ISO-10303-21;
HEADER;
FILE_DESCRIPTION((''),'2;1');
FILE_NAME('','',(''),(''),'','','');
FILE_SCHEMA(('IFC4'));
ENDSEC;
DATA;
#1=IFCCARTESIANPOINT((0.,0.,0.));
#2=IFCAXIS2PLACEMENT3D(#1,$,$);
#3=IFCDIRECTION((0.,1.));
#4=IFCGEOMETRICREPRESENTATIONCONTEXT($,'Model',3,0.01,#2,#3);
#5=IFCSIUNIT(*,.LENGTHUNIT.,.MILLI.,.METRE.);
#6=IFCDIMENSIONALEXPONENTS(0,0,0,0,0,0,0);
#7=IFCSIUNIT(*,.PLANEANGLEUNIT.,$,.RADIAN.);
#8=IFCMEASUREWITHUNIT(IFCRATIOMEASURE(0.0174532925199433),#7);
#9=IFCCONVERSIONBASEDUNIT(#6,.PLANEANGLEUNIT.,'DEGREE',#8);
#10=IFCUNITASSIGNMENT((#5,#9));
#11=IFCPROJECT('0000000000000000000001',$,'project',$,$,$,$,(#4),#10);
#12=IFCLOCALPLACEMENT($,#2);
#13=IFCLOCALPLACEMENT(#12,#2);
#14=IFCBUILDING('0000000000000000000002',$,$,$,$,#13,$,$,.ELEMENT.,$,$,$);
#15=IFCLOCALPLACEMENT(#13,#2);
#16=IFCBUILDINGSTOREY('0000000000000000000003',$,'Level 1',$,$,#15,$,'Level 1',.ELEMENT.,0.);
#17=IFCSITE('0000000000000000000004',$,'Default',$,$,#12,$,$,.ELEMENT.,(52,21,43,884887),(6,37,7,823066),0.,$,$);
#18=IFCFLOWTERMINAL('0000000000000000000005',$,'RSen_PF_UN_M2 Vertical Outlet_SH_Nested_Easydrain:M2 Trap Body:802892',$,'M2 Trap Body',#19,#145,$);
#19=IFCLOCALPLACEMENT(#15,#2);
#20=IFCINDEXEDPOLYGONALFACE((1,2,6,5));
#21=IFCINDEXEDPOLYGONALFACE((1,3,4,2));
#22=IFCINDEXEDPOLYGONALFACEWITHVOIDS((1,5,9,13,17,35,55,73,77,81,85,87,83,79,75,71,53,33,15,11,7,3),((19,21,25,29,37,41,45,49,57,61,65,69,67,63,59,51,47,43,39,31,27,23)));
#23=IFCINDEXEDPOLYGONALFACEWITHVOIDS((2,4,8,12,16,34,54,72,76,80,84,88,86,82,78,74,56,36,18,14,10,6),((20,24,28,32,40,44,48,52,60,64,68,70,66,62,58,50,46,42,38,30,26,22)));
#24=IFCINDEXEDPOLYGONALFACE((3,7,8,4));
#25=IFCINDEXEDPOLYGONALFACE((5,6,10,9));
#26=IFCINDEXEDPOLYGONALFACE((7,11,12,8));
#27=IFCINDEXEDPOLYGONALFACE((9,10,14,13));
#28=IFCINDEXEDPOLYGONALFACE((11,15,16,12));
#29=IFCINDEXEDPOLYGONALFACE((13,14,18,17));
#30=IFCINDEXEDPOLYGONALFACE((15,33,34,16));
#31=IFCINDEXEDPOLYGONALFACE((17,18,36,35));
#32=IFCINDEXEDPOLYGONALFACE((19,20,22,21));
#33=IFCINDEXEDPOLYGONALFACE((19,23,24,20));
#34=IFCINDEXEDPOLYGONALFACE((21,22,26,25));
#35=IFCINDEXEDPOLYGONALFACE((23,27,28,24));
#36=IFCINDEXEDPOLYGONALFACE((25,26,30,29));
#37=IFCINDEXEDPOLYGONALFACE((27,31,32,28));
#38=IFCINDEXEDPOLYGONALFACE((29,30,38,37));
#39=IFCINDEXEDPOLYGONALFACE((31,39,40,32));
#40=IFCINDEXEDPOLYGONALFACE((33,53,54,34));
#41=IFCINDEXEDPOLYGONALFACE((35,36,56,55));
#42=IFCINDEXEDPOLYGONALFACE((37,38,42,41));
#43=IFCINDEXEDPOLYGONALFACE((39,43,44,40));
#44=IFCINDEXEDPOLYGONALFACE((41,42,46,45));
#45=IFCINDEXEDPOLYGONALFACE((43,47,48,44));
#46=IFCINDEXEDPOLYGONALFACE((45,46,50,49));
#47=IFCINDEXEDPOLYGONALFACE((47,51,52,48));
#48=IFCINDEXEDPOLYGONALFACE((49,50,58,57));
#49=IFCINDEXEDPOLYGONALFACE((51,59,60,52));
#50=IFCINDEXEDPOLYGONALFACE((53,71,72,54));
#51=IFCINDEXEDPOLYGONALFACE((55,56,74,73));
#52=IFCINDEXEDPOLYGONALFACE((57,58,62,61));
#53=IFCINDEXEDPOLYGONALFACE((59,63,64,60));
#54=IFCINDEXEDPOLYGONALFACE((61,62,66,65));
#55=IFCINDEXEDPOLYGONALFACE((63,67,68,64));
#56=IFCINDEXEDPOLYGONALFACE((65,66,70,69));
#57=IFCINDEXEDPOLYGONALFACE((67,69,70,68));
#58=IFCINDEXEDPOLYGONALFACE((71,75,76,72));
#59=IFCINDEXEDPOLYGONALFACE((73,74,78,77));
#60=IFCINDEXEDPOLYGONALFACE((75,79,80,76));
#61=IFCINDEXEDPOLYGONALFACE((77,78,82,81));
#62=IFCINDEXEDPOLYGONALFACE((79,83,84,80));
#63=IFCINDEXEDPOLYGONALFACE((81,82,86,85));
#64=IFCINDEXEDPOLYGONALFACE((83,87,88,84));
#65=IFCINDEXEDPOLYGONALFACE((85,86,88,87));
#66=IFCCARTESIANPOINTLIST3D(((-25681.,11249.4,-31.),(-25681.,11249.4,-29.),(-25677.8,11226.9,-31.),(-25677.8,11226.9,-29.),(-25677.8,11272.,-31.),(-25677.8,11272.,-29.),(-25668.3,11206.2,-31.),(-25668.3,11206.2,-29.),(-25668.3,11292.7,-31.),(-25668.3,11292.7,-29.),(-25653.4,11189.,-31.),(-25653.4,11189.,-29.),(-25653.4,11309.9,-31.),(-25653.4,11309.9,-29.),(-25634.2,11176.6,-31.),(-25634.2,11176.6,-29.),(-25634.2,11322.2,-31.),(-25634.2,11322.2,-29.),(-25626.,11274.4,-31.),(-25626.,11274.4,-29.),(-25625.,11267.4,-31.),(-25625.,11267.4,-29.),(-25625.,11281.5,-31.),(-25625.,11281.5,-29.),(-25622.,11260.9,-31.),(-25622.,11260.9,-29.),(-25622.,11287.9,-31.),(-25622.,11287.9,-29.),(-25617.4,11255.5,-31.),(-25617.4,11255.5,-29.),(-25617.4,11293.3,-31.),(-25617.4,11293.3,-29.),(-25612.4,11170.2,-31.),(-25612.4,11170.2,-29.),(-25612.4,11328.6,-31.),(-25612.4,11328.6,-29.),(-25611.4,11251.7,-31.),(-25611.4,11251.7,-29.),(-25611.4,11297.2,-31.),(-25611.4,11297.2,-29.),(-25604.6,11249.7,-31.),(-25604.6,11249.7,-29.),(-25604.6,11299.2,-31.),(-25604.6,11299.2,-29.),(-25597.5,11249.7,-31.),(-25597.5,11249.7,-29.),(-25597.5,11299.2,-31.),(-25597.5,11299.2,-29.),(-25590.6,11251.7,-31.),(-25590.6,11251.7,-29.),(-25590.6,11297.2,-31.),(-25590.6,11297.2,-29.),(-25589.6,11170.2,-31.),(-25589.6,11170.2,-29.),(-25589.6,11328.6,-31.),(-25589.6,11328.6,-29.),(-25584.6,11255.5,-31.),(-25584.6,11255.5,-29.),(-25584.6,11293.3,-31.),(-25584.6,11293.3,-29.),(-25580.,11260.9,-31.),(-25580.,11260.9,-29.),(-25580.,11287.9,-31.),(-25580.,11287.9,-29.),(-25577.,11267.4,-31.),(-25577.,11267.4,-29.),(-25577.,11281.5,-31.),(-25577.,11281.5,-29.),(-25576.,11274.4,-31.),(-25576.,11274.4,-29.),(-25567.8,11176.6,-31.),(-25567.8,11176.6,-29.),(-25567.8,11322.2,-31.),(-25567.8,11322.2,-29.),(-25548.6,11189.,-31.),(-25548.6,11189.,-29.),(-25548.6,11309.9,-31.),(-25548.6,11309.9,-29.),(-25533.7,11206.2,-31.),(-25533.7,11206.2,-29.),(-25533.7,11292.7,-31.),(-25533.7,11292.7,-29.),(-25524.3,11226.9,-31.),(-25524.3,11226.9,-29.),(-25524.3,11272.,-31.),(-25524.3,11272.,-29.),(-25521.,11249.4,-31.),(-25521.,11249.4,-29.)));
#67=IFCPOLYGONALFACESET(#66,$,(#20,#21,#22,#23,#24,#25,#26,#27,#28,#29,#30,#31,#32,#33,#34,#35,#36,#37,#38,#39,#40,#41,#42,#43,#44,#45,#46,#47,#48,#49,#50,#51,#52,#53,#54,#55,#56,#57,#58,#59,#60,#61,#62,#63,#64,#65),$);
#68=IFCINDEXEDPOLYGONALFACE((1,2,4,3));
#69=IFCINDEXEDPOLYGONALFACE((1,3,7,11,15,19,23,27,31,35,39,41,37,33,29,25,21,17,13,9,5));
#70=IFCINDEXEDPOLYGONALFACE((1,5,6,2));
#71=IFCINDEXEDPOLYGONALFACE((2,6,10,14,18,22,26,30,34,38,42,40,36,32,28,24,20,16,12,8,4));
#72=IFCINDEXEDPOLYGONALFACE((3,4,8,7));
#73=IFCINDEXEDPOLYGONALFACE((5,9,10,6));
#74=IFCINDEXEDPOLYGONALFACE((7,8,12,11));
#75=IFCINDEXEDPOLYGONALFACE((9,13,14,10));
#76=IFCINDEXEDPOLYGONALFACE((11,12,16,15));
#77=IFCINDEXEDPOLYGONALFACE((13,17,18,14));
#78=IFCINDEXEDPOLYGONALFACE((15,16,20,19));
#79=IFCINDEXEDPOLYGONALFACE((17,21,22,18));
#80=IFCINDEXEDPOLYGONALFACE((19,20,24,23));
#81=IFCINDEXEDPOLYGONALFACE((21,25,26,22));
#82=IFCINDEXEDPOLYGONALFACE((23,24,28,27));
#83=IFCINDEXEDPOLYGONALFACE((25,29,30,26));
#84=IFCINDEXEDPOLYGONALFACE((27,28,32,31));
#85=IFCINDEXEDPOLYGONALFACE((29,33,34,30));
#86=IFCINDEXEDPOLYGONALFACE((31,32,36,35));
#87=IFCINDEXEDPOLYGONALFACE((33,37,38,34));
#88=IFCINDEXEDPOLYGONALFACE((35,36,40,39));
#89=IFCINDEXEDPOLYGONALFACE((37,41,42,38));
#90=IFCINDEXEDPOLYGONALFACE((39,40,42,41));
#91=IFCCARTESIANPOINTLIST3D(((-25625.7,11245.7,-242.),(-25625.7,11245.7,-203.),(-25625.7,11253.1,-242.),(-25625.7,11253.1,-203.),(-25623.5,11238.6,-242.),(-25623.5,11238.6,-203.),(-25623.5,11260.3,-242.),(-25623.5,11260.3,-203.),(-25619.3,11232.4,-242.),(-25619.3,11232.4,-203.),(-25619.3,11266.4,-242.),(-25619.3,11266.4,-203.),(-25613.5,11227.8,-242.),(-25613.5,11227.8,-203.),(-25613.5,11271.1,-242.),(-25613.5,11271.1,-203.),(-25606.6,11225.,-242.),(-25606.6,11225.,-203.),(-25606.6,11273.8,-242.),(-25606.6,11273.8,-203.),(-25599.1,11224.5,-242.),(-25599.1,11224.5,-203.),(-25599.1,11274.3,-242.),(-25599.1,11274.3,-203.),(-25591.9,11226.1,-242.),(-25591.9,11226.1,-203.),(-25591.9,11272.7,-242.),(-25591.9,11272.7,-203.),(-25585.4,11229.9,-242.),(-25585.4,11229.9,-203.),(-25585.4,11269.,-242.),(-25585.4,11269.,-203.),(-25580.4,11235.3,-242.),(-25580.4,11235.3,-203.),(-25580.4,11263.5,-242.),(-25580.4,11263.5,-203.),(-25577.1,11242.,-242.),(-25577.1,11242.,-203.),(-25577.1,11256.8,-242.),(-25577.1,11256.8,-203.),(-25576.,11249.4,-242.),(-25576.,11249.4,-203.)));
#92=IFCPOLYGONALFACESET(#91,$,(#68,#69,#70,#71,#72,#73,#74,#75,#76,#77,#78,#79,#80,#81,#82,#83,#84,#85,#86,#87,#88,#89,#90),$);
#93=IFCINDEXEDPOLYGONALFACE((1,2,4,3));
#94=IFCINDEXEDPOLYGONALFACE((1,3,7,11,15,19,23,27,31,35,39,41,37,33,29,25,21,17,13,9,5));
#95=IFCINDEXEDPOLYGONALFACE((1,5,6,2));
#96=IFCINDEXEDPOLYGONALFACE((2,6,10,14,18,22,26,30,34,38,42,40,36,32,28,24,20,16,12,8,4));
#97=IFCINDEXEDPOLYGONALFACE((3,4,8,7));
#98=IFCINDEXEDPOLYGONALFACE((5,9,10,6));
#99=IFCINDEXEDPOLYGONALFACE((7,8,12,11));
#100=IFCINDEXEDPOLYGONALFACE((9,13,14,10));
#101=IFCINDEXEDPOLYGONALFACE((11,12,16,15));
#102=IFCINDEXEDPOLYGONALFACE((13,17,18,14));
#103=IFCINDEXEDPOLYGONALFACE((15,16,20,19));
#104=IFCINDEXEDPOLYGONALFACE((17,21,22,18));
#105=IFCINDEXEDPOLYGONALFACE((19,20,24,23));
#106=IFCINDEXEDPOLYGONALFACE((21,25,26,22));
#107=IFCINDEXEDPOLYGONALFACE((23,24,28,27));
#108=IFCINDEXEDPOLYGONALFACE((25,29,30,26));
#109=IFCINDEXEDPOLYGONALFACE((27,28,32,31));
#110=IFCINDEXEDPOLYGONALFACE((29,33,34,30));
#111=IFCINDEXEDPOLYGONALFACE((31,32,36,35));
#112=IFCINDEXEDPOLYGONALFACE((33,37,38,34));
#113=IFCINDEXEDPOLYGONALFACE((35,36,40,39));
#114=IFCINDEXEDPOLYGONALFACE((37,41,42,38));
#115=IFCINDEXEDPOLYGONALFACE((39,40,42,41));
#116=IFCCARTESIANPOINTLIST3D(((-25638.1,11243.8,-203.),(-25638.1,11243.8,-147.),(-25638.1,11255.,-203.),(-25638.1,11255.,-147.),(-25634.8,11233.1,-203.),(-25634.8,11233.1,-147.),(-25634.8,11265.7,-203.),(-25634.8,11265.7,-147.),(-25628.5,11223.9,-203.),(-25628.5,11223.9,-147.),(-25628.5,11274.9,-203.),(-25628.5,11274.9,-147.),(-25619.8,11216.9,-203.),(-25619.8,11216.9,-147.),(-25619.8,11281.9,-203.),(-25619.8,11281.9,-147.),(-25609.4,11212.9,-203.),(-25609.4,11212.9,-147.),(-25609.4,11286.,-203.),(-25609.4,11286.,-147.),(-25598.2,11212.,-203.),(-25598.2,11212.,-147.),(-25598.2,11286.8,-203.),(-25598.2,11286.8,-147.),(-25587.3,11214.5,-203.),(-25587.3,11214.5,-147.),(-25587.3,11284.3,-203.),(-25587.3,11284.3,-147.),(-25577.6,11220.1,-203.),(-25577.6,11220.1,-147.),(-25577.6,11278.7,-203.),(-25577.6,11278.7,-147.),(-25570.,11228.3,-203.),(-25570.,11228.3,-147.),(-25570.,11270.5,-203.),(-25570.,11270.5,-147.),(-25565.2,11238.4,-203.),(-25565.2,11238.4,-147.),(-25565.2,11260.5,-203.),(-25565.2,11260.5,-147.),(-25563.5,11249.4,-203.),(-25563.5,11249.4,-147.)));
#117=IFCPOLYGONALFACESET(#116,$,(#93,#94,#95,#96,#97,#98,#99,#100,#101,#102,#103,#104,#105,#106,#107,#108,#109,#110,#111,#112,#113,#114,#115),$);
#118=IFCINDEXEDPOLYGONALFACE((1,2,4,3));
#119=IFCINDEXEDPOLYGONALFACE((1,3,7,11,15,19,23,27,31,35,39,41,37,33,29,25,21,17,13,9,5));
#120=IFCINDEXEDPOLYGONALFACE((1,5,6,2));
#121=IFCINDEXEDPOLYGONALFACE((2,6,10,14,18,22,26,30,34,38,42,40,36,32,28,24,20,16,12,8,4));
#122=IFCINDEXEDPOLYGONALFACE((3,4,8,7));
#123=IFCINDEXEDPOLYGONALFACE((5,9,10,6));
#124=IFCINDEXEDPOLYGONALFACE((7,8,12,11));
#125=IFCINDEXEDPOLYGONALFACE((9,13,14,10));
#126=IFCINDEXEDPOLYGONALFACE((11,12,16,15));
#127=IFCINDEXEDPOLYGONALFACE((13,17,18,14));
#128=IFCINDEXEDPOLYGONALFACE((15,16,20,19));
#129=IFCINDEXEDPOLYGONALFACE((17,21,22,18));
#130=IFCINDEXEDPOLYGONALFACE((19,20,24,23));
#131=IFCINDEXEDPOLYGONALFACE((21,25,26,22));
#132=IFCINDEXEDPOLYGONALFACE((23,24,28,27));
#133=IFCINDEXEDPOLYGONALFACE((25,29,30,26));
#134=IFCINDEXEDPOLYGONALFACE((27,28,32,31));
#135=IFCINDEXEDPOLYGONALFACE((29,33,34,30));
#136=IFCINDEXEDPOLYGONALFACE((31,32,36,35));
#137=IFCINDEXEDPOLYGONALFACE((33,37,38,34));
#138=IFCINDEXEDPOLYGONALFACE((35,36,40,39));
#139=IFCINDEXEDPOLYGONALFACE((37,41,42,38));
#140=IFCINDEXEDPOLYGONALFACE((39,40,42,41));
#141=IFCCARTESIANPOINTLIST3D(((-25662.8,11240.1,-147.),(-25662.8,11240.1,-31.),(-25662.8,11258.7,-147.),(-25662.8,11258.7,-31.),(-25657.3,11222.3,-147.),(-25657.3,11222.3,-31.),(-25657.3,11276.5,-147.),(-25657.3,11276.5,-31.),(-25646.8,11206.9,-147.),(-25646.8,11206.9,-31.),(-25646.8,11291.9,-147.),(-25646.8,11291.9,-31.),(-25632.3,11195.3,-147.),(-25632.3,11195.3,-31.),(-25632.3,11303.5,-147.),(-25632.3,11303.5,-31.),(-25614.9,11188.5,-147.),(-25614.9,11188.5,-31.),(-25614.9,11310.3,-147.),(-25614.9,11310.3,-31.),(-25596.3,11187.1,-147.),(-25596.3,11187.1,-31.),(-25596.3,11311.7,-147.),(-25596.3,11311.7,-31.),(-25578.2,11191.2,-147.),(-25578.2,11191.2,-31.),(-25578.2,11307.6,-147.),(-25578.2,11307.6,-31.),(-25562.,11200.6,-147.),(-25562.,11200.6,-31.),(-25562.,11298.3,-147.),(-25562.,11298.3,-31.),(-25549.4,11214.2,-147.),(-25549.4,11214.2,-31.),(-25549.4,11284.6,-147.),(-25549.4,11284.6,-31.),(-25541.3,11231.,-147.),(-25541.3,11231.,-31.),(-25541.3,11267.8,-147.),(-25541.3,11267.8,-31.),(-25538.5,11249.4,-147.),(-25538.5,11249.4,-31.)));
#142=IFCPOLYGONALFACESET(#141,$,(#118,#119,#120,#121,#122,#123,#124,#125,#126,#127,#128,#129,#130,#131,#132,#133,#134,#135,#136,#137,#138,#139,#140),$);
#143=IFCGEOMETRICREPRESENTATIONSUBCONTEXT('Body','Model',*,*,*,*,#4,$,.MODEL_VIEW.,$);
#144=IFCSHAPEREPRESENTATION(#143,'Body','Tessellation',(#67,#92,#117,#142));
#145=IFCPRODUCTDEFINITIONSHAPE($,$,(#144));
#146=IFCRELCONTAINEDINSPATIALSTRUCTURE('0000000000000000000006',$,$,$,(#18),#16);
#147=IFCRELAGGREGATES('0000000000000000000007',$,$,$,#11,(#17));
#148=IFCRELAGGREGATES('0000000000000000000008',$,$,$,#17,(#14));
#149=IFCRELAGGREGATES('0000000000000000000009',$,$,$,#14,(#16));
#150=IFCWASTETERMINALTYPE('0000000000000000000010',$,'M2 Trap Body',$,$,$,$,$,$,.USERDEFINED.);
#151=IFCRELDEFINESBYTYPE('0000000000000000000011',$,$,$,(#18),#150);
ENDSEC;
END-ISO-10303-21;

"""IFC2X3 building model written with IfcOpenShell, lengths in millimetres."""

from ifc_helpers import new_model, entity, si_unit, converted_unit, direction, frame, frame_2d, origin, origin_2d_with_axis, place, context, subcontext, project, spatial, circle_curve, parameter, trimmed, segment, composite_curve, circle, outline, extrude, source, transform, mapped, type_object, type_shapes, element, save


model = new_model("IFC2X3")

# Units and contexts
model_context = context("Model", 3, precision=0.01, world=origin(), true_north=direction((0.0, 1.0)))
body_context = subcontext(model_context, "Body", "Model", "MODEL_VIEW")
ifc_project = project(units=[si_unit("LENGTHUNIT", "METRE", prefix="MILLI"), converted_unit("PLANEANGLEUNIT", "DEGREE", entity("IfcRatioMeasure", 0.0174532925199433), si_unit("PLANEANGLEUNIT", "RADIAN"), dimensions=[0, 0, 0, 0, 0, 0, 0])], contexts=[model_context])

# Site, building, storey
site_placement = place(None, origin())
site = spatial("IfcSite", under=ifc_project, at=site_placement, Name="Default", CompositionType="ELEMENT", RefLatitude=(52, 21, 43, 884887), RefLongitude=(6, 37, 7, 823066), RefElevation=0.0)
building_placement = place(site_placement, origin())
building = spatial("IfcBuilding", under=site, at=building_placement, CompositionType="ELEMENT")
storey_placement = place(building_placement, origin())
storey = spatial("IfcBuildingStorey", under=building, at=storey_placement, Name="Level 1", LongName="Level 1", CompositionType="ELEMENT", Elevation=0.0)

# Flow terminal
waste_terminal_type_1 = type_object("IfcWasteTerminalType", Name="M2 Trap Body", PredefinedType="USERDEFINED")
shared_shape_1 = source(origin(), body_context, "Body", "SweptSolid", [
    extrude(outline(composite_curve([segment(trimmed(circle_curve(origin_2d_with_axis(), 80.0), [parameter(0.0)], [parameter(180.0)], True, "PARAMETER"), True, "CONTINUOUS"), segment(trimmed(circle_curve(origin_2d_with_axis(), 80.0), [parameter(180.0)], [parameter(360.0)], True, "PARAMETER"), True, "CONTINUOUS")], self_intersect=False), holes=[composite_curve([segment(trimmed(circle_curve(frame_2d((0.0, 25.0), x_axis=(1.0, 0.0)), 25.0), [parameter(180.0)], [parameter(360.0)], True, "PARAMETER"), False, "CONTINUOUS"), segment(trimmed(circle_curve(frame_2d((0.0, 25.0), x_axis=(1.0, 0.0)), 25.0), [parameter(0.0)], [parameter(180.0)], True, "PARAMETER"), False, "CONTINUOUS")], self_intersect=False)]), frame((0.0, -25.0, -2.0)), (0.0, 0.0, 1.0), 2.0),
    extrude(circle(Radius=25.0, at=frame_2d((0.0, 0.0), x_axis=(1.0, 0.0))), frame((0.0, -25.0, -213.0)), (0.0, 0.0, 1.0), 39.0),
    extrude(circle(Radius=37.5, at=frame_2d((0.0, 0.0), x_axis=(1.0, 0.0))), frame((0.0, -25.0, -174.0)), (0.0, 0.0, 1.0), 56.0),
    extrude(circle(Radius=62.5, at=frame_2d((0.0, 0.0), x_axis=(1.0, 0.0))), frame((0.0, -25.0, -118.0)), (0.0, 0.0, 1.0), 116.0),
])
type_shapes(waste_terminal_type_1, [shared_shape_1])
for number, where, name in (
    (1, (-25601.0, 11274.4, -29.0), "RSen_PF_UN_M2 Vertical Outlet_SH_Nested_Easydrain:M2 Trap Body:802892"),
):
    element("IfcFlowTerminal", number, at=place(storey_placement, frame(where)), inside=storey, type_object=waste_terminal_type_1, Name=name, ObjectType="M2 Trap Body", context=body_context, shape_type="MappedRepresentation", body=[
        mapped(shared_shape_1, transform((0.0, 0.0, 0.0), scale=1.0)),
    ])

save(model, "model.ifc")
